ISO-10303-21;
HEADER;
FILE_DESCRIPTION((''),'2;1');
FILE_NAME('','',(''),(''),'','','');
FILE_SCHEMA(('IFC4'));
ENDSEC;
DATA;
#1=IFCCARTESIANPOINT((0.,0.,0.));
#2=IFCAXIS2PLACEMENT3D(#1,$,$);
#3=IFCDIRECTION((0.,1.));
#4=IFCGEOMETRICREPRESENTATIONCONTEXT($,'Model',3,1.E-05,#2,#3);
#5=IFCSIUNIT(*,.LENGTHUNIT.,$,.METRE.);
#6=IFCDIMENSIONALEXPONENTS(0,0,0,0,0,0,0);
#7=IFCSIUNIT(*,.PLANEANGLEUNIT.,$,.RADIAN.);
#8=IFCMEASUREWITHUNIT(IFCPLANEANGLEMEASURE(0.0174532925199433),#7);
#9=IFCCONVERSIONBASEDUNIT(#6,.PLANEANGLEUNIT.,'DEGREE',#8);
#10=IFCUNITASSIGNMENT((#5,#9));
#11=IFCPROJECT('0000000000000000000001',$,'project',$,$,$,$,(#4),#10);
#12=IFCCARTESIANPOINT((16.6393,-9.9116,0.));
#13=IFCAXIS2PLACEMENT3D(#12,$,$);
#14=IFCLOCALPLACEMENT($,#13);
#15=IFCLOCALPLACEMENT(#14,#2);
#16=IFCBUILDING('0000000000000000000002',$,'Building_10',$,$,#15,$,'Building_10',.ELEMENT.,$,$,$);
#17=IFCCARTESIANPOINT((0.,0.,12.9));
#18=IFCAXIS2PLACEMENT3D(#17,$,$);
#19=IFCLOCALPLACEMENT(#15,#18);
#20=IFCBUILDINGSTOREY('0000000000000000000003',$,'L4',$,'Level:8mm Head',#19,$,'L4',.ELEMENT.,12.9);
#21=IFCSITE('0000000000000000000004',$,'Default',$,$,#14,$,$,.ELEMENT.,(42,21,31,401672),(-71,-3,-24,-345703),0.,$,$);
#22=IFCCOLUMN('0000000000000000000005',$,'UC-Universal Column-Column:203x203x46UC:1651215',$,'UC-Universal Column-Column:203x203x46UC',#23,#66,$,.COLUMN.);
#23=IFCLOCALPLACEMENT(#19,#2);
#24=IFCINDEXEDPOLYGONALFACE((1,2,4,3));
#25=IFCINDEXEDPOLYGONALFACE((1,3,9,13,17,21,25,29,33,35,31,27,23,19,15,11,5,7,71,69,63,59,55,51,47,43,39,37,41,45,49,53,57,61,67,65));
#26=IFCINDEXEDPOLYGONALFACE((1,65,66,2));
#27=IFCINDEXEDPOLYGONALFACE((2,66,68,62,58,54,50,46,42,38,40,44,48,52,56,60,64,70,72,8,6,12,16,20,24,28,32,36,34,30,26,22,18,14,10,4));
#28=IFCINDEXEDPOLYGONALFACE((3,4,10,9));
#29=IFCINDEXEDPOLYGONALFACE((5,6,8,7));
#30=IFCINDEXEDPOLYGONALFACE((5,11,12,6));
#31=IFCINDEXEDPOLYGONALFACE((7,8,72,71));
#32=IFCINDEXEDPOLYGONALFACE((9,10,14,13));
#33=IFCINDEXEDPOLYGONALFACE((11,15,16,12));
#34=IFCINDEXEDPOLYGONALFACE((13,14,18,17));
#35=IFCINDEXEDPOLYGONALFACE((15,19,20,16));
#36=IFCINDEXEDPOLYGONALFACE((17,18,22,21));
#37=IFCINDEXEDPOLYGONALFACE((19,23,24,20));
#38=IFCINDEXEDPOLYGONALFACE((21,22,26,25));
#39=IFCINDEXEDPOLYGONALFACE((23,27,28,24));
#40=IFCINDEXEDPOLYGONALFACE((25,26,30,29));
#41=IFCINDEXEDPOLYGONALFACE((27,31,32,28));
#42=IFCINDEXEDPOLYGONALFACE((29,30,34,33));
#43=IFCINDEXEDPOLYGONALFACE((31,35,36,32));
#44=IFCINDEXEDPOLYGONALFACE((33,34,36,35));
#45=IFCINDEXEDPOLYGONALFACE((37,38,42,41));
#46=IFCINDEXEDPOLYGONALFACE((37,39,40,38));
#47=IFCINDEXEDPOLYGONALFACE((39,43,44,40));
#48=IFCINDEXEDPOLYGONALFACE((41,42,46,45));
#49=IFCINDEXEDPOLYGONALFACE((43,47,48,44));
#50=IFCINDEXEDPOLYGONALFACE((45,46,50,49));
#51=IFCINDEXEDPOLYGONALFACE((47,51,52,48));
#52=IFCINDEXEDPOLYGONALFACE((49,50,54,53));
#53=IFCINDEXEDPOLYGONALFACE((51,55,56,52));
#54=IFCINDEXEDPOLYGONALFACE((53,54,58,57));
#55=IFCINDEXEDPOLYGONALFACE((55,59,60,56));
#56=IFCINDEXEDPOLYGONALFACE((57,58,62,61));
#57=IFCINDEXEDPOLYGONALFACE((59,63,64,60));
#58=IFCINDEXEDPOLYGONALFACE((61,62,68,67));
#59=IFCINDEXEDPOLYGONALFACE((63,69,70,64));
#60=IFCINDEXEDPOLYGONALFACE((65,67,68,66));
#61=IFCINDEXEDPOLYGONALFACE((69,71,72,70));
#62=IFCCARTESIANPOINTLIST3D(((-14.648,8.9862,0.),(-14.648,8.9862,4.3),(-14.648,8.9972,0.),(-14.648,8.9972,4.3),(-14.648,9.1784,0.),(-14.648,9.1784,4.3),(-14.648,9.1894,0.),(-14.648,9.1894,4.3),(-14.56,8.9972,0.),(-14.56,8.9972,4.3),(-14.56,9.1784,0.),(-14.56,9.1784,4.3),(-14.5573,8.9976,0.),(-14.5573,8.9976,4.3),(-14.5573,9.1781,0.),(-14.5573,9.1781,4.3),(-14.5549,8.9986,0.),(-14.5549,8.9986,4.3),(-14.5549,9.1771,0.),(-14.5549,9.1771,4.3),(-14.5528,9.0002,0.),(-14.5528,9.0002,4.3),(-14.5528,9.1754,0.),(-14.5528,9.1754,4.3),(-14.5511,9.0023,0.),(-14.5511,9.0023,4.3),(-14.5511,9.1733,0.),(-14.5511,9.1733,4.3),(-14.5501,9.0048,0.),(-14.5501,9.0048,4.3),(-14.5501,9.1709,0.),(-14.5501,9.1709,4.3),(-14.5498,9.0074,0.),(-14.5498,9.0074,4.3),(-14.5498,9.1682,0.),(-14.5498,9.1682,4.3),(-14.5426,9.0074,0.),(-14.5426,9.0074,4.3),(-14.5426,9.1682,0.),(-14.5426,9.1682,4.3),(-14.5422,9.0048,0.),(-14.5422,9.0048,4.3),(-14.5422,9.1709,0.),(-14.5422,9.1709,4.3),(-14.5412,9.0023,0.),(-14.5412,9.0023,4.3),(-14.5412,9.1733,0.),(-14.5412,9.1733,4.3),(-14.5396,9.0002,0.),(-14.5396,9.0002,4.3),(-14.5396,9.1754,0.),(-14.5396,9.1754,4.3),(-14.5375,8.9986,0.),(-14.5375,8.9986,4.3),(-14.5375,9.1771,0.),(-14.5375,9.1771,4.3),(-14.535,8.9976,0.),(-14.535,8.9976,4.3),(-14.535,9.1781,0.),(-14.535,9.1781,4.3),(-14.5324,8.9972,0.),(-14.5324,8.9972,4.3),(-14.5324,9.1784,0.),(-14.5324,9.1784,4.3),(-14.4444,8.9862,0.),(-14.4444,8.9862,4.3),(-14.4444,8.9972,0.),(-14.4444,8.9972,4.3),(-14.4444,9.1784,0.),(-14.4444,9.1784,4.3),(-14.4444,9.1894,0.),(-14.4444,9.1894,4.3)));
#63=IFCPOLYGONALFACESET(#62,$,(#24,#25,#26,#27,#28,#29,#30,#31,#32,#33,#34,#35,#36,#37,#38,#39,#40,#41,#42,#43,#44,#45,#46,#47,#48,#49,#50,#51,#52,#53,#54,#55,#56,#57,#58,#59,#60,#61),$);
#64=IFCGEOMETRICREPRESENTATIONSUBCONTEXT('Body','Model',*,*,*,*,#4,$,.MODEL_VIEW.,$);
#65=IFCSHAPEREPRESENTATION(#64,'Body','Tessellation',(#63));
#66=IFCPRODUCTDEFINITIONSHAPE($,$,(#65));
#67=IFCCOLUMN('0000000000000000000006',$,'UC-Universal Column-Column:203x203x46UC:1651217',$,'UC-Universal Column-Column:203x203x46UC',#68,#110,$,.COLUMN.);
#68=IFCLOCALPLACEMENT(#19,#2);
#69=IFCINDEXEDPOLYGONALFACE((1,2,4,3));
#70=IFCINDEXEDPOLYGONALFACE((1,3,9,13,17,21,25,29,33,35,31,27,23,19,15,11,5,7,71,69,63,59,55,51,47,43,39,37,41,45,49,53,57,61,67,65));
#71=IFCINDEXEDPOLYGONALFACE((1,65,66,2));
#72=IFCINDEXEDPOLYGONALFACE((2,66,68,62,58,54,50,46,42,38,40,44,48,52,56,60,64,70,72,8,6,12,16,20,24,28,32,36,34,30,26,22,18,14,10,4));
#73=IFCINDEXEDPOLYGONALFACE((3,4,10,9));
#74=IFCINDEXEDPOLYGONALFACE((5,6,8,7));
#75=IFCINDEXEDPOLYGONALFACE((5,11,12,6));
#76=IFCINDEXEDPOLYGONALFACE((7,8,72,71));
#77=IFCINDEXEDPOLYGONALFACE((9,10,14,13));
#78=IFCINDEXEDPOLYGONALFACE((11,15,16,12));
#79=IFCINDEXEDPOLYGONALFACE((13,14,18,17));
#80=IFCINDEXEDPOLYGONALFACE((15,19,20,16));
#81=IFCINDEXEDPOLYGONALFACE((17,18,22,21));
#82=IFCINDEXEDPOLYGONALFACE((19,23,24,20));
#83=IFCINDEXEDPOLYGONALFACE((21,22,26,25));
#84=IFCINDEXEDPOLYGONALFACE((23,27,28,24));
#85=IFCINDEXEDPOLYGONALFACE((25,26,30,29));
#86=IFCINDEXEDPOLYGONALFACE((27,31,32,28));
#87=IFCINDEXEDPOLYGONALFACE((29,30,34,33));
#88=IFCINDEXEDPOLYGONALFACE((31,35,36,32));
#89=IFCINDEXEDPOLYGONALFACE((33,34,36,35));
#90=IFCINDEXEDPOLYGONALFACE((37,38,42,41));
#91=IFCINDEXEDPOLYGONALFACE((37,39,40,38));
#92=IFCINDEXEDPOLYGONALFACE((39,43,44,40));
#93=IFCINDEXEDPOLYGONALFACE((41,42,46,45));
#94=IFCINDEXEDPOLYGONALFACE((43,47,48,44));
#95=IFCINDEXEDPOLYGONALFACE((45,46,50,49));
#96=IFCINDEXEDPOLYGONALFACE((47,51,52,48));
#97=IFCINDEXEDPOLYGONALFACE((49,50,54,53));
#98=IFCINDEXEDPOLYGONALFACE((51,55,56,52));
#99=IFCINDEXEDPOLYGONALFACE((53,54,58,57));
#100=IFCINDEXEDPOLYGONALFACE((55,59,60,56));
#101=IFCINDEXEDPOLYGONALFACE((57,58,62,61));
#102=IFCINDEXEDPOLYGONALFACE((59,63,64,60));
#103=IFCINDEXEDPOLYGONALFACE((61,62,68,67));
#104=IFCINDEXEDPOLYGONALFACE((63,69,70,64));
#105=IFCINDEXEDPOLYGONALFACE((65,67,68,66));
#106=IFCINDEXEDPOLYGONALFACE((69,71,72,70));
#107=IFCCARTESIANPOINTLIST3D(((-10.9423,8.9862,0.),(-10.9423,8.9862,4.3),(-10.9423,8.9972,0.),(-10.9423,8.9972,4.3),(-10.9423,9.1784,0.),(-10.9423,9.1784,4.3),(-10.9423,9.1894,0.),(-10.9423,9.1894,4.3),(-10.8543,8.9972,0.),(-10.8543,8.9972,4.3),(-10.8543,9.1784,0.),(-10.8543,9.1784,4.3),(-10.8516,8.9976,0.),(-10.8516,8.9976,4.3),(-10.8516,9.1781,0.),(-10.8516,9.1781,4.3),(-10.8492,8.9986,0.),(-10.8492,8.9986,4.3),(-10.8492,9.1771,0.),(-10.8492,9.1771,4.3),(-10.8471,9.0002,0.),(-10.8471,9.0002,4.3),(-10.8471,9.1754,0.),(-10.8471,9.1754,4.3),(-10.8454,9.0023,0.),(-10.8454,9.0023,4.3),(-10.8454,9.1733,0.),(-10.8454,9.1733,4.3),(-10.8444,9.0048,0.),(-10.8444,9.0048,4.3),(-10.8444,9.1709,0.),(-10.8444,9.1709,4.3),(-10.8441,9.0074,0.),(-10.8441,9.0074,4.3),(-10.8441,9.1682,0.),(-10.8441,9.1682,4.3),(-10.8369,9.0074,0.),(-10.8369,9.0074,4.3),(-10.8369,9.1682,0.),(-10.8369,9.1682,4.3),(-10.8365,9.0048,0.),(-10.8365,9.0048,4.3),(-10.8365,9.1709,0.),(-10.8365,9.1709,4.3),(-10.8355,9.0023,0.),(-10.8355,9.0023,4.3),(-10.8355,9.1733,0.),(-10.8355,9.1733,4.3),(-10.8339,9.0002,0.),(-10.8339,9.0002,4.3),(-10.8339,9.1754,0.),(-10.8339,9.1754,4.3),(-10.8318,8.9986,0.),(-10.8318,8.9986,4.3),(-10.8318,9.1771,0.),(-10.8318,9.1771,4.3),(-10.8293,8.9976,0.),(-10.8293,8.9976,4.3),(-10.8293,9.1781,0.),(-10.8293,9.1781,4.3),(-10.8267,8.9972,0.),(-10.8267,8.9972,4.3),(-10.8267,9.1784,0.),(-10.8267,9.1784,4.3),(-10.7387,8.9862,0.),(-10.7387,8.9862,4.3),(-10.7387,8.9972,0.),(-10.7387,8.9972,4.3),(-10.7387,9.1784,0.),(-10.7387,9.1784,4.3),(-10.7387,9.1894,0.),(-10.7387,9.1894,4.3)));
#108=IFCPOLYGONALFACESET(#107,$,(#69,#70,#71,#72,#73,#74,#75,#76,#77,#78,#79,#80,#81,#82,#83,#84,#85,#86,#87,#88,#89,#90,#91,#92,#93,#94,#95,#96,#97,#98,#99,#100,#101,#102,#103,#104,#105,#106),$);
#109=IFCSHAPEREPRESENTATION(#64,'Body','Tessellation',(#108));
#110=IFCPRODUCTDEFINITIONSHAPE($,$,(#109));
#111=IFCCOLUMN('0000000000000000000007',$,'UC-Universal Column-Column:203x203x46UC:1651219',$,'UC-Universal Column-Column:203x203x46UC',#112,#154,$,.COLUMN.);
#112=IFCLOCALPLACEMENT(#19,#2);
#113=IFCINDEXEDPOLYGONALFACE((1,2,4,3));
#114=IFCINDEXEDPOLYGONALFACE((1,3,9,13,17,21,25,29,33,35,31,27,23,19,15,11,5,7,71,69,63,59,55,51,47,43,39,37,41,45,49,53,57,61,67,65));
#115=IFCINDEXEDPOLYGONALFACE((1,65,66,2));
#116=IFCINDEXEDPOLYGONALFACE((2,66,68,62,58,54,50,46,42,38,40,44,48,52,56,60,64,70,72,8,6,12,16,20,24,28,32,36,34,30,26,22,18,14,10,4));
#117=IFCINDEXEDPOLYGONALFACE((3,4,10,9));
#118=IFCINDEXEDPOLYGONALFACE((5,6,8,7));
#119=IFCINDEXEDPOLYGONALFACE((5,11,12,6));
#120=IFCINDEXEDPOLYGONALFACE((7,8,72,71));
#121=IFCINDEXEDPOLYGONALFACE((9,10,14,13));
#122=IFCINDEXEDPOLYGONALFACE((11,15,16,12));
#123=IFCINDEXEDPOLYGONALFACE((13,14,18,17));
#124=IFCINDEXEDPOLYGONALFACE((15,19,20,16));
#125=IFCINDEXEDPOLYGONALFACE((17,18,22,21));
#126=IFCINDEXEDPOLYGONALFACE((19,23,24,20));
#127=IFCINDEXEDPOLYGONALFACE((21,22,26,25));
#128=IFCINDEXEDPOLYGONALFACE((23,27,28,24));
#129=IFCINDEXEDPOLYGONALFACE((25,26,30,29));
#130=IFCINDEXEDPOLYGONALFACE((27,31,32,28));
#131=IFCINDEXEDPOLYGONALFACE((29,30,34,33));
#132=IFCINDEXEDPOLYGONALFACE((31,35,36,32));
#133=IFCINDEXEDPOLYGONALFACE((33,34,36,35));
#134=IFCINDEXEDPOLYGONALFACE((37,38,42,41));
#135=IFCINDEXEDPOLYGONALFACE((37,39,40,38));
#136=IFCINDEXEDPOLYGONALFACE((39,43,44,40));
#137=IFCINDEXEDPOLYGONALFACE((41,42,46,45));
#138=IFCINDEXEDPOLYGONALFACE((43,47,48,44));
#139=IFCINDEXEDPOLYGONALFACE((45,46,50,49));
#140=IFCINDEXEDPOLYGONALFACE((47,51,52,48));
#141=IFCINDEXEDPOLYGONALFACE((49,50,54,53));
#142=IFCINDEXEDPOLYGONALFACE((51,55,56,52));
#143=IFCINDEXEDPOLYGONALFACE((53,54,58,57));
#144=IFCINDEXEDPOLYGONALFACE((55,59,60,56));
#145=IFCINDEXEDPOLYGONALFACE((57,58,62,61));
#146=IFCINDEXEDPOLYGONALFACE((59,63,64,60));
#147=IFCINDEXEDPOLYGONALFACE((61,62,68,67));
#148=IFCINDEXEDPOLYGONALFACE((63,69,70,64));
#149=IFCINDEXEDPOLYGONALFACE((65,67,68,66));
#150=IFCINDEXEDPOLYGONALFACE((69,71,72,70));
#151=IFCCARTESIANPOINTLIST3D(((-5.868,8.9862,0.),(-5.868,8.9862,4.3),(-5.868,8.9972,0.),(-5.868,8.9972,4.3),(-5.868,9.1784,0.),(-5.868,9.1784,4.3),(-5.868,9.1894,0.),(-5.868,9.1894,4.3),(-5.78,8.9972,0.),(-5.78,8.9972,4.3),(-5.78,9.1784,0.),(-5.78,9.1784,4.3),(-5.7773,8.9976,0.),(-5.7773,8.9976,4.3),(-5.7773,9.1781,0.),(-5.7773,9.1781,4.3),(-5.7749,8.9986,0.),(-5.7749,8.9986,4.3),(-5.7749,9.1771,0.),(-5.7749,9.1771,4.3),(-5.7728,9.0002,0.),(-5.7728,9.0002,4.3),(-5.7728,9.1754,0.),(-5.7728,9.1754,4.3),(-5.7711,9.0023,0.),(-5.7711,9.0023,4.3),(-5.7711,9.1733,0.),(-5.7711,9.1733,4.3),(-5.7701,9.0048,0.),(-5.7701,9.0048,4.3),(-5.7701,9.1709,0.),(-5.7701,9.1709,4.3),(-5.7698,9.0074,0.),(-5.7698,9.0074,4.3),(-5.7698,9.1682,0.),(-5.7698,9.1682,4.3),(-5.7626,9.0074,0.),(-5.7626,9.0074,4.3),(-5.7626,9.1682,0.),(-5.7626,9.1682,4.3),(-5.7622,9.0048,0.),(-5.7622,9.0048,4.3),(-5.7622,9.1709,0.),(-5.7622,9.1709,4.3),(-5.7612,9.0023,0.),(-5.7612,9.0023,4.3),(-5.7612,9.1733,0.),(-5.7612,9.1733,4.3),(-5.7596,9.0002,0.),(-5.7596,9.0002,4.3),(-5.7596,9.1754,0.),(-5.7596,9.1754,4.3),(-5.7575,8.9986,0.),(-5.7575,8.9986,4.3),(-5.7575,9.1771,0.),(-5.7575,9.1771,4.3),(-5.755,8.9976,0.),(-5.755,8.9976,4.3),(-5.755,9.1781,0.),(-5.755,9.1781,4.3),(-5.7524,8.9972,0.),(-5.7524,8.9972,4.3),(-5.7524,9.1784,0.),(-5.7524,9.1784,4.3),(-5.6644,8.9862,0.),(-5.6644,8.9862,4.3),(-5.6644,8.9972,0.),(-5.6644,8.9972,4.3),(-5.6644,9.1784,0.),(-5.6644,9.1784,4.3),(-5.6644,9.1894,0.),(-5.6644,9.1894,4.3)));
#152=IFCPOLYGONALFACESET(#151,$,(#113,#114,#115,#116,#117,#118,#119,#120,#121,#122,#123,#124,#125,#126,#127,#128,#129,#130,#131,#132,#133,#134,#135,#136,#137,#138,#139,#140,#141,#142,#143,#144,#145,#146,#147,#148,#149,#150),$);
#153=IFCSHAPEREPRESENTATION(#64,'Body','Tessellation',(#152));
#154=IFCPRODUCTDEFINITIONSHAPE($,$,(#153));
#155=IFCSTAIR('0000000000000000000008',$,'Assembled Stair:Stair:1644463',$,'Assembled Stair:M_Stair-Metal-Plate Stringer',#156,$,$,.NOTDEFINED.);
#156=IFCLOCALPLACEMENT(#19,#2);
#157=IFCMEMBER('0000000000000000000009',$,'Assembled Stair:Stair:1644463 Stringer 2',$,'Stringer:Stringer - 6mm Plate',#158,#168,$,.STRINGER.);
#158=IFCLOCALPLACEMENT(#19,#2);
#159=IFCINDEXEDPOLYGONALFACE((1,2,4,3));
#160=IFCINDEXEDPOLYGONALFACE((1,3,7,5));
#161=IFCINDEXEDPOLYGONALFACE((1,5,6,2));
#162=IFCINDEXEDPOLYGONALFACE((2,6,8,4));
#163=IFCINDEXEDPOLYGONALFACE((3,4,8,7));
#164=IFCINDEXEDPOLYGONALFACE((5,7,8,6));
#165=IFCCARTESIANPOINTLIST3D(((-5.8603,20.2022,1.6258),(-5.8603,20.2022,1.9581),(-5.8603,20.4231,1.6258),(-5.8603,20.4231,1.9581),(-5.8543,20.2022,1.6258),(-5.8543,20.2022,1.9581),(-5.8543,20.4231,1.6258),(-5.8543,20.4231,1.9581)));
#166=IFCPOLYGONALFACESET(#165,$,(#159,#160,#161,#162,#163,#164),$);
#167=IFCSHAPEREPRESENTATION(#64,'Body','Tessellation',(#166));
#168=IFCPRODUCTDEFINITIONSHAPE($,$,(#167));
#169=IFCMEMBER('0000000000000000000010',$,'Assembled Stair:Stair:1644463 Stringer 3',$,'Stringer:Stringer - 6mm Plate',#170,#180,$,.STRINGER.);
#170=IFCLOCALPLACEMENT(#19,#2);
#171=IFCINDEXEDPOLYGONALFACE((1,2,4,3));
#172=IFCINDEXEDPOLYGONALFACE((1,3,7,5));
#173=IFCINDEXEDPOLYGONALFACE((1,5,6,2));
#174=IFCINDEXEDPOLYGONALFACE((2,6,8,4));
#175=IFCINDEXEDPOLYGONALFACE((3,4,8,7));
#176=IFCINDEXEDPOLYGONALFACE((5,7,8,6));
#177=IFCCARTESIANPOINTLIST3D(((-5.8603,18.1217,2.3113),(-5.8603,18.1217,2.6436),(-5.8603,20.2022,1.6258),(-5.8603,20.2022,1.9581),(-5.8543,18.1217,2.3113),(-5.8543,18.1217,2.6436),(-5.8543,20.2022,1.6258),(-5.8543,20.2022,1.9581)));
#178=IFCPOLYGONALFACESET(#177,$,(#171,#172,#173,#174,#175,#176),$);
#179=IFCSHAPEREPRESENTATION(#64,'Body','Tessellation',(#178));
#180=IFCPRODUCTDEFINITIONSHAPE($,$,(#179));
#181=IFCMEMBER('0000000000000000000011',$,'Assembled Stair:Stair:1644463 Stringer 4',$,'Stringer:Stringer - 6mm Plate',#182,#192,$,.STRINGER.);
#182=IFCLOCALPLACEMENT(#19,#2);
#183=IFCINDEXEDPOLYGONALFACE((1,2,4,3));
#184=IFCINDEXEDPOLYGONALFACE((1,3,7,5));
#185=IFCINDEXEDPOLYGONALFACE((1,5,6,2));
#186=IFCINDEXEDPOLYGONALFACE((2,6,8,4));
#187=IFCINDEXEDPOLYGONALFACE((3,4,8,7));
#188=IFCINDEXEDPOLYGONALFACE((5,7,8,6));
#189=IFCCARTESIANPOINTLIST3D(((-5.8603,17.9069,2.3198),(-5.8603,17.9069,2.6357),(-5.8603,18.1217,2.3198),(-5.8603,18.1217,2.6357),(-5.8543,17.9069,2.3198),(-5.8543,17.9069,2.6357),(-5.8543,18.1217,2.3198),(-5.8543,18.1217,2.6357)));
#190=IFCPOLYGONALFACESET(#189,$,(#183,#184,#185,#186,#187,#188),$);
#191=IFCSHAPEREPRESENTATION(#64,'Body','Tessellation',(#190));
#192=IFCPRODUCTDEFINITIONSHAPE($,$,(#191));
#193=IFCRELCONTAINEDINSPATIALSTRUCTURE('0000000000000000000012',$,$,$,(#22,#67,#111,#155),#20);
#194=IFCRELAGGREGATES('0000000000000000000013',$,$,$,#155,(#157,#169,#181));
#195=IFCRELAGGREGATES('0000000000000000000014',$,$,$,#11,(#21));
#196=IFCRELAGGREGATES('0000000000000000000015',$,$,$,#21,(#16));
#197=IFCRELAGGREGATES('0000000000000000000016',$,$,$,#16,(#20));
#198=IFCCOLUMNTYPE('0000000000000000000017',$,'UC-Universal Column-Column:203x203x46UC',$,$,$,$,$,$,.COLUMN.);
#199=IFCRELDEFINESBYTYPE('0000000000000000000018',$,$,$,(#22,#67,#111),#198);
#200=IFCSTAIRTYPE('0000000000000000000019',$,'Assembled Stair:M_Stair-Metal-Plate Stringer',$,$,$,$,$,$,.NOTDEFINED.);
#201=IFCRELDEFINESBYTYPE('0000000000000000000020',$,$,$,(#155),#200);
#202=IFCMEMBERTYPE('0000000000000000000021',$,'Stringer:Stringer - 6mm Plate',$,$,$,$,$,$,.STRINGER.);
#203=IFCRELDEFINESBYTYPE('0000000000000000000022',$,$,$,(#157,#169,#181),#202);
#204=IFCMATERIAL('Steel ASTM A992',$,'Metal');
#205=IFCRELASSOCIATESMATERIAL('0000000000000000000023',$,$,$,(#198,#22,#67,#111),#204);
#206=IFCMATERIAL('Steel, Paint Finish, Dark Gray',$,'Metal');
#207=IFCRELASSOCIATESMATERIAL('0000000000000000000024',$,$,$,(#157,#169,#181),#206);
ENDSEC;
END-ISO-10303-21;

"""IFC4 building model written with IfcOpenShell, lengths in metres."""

from ifc_helpers import new_model, entity, si_unit, converted_unit, direction, frame, origin, place, context, subcontext, project, spatial, line, arc, indexed_curve, outline, extrude, source, transform, mapped, material, type_object, type_shapes, element, aggregate, save


model = new_model("IFC4")

# Units and contexts
model_context = context("Model", 3, precision=1e-05, world=origin(), true_north=direction((0.0, 1.0)))
body_context = subcontext(model_context, "Body", "Model", "MODEL_VIEW")
ifc_project = project(units=[si_unit("LENGTHUNIT", "METRE"), converted_unit("PLANEANGLEUNIT", "DEGREE", entity("IfcPlaneAngleMeasure", 0.0174532925199433), si_unit("PLANEANGLEUNIT", "RADIAN"), dimensions=[0, 0, 0, 0, 0, 0, 0])], contexts=[model_context])

# Site, building, storey
site_placement = place(None, frame((16.6393, -9.9116, 0.0)))
site = spatial("IfcSite", under=ifc_project, at=site_placement, Name="Default", CompositionType="ELEMENT", RefLatitude=(42, 21, 31, 401672), RefLongitude=(-71, -3, -24, -345703), RefElevation=0.0)
building_placement = place(site_placement, origin())
building = spatial("IfcBuilding", under=site, at=building_placement, Name="Building_10", LongName="Building_10", CompositionType="ELEMENT")
storey_placement = place(building_placement, frame((0.0, 0.0, 12.9)))
storey = spatial("IfcBuildingStorey", under=building, at=storey_placement, Name="L4", ObjectType="Level:8mm Head", LongName="L4", CompositionType="ELEMENT", Elevation=12.9)

# Columns
ifc_material_1 = material(Name="Steel ASTM A992", Category="Metal")
column_type = type_object("IfcColumnType", Name="UC-Universal Column-Column:203x203x46UC", PredefinedType="COLUMN", material=ifc_material_1)
shared_shape_1 = source(origin(), body_context, "Body", "SweptSolid", [
    extrude(outline(indexed_curve([(-0.1018, -0.1016), (0.1018, -0.1016), (0.1018, -0.0906), (0.0138, -0.0906), (0.0066, -0.0876), (0.0036, -0.0804), (0.0036, 0.0804), (0.0066, 0.0876), (0.0138, 0.0906), (0.1018, 0.0906), (0.1018, 0.1016), (-0.1018, 0.1016), (-0.1018, 0.0906), (-0.0138, 0.0906), (-0.0066, 0.0876), (-0.0036, 0.0804), (-0.0036, -0.0804), (-0.0066, -0.0876), (-0.0138, -0.0906), (-0.1018, -0.0906)], segments=[line(1, 2, 3, 4), arc(4, 5, 6), line(6, 7), arc(7, 8, 9), line(9, 10, 11, 12, 13, 14), arc(14, 15, 16), line(16, 17), arc(17, 18, 19), line(19, 20, 1)], self_intersect=False)), frame((0.0, 0.0, 12.9), z_axis=(0.0, 0.0, 1.0), x_axis=(-1.0, 0.0, 0.0)), (0.0, 0.0, 1.0), 4.3),
])
type_shapes(column_type, [shared_shape_1])
for number, where, name in (
    (1, (-14.5462, 9.0878, -12.9), "UC-Universal Column-Column:203x203x46UC:1651215"),
    (2, (-10.8405, 9.0878, -12.9), "UC-Universal Column-Column:203x203x46UC:1651217"),
    (3, (-5.7662, 9.0878, -12.9), "UC-Universal Column-Column:203x203x46UC:1651219"),
):
    element("IfcColumn", number, at=place(storey_placement, frame(where)), inside=storey, type_object=column_type, material=ifc_material_1, Name=name, ObjectType="UC-Universal Column-Column:203x203x46UC", PredefinedType="COLUMN", context=body_context, shape_type="MappedRepresentation", body=[
        mapped(shared_shape_1, transform((0.0, 0.0, 0.0), scale=1.0)),
    ])

# Stair, members
stair_type = type_object("IfcStairType", Name="Assembled Stair:M_Stair-Metal-Plate Stringer", PredefinedType="NOTDEFINED")
stair_1_placement = place(storey_placement, origin())
stair_1 = element("IfcStair", 4, at=stair_1_placement, inside=storey, type_object=stair_type, Name="Assembled Stair:Stair:1644463", ObjectType="Assembled Stair:M_Stair-Metal-Plate Stringer", PredefinedType="NOTDEFINED")
ifc_material_2 = material(Name="Steel, Paint Finish, Dark Gray", Category="Metal")
member_type = type_object("IfcMemberType", Name="Stringer:Stringer - 6mm Plate", PredefinedType="STRINGER")
member_1_placement = place(stair_1_placement, origin())
member_1 = element("IfcMember", 5, at=member_1_placement, type_object=member_type, material=ifc_material_2, Name="Assembled Stair:Stair:1644463 Stringer 2", ObjectType="Stringer:Stringer - 6mm Plate", PredefinedType="STRINGER", context=body_context, shape_type="SweptSolid", body=[
    extrude(outline(indexed_curve([(-0.1104, -0.003), (0.1104, -0.003), (0.1104, 0.003), (-0.1104, 0.003), (-0.1104, -0.003)], self_intersect=False)), frame((-5.8573, 20.3126, 1.6258), z_axis=(0.0, 0.0, 1.0), x_axis=(0.0, -1.0, 0.0)), (0.0, 0.0, 1.0), 0.3323),
])
member_2_placement = place(stair_1_placement, origin())
member_2 = element("IfcMember", 6, at=member_2_placement, type_object=member_type, material=ifc_material_2, Name="Assembled Stair:Stair:1644463 Stringer 3", ObjectType="Stringer:Stringer - 6mm Plate", PredefinedType="STRINGER", context=body_context, shape_type="SweptSolid", body=[
    extrude(outline(indexed_curve([(-1.0433, -0.1578), (1.1473, -0.1578), (1.0433, 0.1578), (-1.1473, 0.1578), (-1.0433, -0.1578)], self_intersect=False)), frame((-5.8603, 19.162, 2.1347), z_axis=(1.0, 0.0, 0.0), x_axis=(0.0, -0.949774, 0.312936)), (0.0, 0.0, 1.0), 0.006),
])
member_3_placement = place(stair_1_placement, origin())
member_3 = element("IfcMember", 7, at=member_3_placement, type_object=member_type, material=ifc_material_2, Name="Assembled Stair:Stair:1644463 Stringer 4", ObjectType="Stringer:Stringer - 6mm Plate", PredefinedType="STRINGER", context=body_context, shape_type="SweptSolid", body=[
    extrude(outline(indexed_curve([(-0.1074, -0.003), (0.1074, -0.003), (0.1074, 0.003), (-0.1074, 0.003), (-0.1074, -0.003)], self_intersect=False)), frame((-5.8573, 18.0143, 2.3198), z_axis=(0.0, 0.0, 1.0), x_axis=(0.0, -1.0, 0.0)), (0.0, 0.0, 1.0), 0.3159),
])
aggregate(stair_1, [member_1, member_2, member_3])

save(model, "model.ifc")
